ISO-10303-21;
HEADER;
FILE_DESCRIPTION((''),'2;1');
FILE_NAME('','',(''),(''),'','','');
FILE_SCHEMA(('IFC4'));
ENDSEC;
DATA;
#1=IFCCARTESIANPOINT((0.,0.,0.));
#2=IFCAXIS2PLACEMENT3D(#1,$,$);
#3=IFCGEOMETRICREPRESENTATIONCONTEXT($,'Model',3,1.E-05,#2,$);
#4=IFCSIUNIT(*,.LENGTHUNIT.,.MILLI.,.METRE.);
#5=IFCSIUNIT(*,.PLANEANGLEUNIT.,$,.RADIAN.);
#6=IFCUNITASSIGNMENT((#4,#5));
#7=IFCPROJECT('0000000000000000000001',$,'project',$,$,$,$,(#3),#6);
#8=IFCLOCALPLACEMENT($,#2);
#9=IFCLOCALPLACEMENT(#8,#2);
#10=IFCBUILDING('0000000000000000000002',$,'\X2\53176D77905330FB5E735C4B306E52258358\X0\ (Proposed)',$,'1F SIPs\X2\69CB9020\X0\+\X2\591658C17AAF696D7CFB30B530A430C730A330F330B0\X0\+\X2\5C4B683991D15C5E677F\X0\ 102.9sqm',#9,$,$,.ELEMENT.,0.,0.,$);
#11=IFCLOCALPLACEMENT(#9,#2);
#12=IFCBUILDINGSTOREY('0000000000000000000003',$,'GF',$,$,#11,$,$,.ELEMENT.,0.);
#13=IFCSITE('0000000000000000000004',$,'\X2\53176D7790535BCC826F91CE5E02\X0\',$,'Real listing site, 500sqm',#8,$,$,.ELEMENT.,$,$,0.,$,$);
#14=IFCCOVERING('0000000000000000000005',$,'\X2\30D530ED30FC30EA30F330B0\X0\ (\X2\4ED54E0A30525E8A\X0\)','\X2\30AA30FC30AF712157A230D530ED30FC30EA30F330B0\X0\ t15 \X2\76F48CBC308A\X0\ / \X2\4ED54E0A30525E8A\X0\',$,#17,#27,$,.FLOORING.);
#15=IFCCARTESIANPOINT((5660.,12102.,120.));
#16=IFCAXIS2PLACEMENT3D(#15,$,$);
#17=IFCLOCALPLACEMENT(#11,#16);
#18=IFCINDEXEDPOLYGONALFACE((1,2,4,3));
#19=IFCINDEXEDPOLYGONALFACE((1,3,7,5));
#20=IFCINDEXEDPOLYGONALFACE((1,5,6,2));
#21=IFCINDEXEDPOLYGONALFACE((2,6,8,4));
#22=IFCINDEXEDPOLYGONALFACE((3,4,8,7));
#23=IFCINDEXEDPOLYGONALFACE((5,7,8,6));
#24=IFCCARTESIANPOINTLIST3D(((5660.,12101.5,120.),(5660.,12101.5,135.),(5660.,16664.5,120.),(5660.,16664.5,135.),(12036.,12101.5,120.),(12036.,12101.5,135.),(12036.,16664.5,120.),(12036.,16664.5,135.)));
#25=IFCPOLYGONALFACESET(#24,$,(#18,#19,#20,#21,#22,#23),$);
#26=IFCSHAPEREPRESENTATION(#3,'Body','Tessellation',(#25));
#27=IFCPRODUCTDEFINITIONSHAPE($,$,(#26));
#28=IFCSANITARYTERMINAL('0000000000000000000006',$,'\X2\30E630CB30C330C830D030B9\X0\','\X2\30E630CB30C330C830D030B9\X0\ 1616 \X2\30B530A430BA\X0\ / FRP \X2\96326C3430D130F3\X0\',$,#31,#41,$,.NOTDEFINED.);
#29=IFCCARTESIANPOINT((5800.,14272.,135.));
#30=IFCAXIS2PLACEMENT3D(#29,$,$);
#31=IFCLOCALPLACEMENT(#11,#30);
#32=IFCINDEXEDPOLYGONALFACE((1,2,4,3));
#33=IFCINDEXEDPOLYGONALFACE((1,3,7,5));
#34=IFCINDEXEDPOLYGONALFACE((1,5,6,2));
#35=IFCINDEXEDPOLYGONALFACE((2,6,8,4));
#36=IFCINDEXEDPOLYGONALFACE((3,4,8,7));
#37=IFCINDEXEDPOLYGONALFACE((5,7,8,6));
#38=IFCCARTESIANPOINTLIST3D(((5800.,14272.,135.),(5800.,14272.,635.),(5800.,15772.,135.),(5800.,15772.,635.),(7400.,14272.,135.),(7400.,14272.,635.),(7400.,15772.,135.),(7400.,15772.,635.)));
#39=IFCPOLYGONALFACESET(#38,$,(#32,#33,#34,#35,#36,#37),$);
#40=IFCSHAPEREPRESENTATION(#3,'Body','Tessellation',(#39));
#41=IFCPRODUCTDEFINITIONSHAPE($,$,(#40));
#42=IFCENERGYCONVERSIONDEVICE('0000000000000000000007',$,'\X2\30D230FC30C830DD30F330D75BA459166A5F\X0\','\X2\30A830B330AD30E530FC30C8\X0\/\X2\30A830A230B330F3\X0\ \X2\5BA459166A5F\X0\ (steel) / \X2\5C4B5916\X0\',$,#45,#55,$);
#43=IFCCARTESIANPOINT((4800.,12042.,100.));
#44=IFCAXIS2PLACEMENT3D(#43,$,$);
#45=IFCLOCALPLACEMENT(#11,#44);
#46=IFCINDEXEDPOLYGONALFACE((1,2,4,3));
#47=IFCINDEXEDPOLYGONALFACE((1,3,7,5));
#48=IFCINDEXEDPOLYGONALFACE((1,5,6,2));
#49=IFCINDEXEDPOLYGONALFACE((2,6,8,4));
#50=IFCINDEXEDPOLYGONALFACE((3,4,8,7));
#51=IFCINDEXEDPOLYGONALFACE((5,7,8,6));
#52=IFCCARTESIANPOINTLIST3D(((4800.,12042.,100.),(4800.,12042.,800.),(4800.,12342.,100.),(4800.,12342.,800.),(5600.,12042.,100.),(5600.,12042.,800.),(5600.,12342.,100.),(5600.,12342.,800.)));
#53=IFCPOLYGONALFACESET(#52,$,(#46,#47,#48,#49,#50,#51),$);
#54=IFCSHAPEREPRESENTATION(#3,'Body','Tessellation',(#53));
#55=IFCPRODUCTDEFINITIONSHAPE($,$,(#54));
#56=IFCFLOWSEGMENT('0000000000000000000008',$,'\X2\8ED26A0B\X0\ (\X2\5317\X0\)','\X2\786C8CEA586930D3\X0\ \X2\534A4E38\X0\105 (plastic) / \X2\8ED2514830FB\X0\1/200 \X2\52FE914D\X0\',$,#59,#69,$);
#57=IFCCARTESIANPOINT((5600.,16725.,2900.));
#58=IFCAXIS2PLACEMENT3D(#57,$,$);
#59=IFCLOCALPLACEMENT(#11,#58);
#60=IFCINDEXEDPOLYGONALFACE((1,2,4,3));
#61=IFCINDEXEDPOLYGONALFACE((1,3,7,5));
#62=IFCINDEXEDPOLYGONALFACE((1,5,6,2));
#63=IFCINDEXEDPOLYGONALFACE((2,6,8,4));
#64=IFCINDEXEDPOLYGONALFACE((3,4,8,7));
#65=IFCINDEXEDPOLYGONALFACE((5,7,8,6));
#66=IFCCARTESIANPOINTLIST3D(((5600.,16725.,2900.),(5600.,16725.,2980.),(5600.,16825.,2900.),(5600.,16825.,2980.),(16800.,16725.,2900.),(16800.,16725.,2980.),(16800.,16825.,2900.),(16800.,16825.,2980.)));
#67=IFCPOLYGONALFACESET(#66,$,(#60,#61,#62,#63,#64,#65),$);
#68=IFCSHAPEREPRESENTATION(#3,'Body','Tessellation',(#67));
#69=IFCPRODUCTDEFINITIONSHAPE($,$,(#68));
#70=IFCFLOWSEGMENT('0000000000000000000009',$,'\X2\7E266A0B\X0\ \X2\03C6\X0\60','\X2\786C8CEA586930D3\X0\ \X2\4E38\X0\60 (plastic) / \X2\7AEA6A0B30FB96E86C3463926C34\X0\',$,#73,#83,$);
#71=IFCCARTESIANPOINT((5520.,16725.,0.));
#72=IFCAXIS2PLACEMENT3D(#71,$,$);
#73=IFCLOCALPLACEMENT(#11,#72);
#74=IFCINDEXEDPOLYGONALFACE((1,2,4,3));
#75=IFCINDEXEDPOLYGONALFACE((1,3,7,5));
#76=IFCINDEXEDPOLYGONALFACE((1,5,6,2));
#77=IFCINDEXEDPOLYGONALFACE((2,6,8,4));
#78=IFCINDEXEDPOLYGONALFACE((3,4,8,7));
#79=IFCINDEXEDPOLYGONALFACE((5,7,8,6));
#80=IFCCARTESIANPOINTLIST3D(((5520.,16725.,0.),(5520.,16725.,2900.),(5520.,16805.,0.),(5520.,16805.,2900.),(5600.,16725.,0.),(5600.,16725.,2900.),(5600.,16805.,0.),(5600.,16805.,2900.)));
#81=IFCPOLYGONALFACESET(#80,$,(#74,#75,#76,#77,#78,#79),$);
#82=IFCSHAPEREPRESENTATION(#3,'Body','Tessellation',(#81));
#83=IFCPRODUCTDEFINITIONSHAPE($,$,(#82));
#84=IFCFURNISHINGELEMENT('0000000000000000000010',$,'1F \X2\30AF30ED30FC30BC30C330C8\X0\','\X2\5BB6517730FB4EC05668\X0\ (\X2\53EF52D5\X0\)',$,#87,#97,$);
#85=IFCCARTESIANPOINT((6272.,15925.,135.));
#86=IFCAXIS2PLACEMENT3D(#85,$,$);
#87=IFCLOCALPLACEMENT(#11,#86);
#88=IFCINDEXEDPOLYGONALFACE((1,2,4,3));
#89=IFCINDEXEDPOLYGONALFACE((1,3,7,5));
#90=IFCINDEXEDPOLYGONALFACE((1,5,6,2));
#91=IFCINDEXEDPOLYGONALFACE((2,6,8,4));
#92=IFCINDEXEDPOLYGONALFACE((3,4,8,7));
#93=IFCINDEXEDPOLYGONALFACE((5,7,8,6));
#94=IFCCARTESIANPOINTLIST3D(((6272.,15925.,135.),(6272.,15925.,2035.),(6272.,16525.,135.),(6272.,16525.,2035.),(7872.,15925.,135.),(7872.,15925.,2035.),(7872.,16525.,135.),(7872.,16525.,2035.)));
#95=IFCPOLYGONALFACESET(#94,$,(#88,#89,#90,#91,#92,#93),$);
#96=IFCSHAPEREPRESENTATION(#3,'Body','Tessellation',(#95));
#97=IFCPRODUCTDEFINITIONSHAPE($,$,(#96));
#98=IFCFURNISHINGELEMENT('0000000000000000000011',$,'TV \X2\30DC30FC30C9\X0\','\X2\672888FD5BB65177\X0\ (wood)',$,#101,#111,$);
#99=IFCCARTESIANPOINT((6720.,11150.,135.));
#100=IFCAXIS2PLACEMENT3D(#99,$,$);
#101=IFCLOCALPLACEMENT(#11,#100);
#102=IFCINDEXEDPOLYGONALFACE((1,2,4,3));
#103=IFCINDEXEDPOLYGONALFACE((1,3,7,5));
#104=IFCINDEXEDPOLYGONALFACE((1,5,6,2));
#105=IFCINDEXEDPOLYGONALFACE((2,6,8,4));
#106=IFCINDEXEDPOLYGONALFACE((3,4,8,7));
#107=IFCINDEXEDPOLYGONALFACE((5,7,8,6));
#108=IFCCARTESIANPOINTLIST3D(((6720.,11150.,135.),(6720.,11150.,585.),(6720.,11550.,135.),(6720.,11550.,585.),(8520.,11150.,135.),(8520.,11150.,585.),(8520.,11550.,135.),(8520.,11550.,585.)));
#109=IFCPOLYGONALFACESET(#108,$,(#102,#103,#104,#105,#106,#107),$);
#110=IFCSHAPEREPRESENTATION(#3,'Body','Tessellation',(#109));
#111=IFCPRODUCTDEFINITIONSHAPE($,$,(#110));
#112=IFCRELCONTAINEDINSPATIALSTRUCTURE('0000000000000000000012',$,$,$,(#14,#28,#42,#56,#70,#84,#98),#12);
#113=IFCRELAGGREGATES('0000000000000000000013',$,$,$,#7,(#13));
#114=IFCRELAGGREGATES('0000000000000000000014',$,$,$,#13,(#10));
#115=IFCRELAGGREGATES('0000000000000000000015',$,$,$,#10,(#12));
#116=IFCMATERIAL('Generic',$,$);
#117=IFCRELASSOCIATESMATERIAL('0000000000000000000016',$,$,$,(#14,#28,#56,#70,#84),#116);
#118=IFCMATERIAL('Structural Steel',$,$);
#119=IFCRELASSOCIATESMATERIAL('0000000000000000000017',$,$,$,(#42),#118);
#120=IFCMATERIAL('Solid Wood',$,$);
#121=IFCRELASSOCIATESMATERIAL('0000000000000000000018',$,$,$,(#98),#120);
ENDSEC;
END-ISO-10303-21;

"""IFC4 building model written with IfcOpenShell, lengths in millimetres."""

from ifc_helpers import new_model, si_unit, frame, frame_2d, origin, place, context, project, spatial, rectangle, extrude, material, element, save


model = new_model("IFC4")

# Units and contexts
model_context = context("Model", 3, precision=1e-05, world=origin())
ifc_project = project(units=[si_unit("LENGTHUNIT", "METRE", prefix="MILLI"), si_unit("PLANEANGLEUNIT", "RADIAN")], contexts=[model_context])

# Site, building, storey
site_placement = place(None, origin())
site = spatial("IfcSite", under=ifc_project, at=site_placement, Name="北海道富良野市", ObjectType="Real listing site, 500sqm", CompositionType="ELEMENT", RefElevation=0.0)
building_placement = place(site_placement, origin())
building = spatial("IfcBuilding", under=site, at=building_placement, Name="北海道・平屋の別荘 (Proposed)", ObjectType="1F SIPs構造+外壁窯業系サイディング+屋根金属板 102.9sqm", CompositionType="ELEMENT", ElevationOfRefHeight=0.0, ElevationOfTerrain=0.0)
storey_placement = place(building_placement, origin())
storey = spatial("IfcBuildingStorey", under=building, at=storey_placement, Name="GF", CompositionType="ELEMENT", Elevation=0.0)

# Shared definitions
ifc_material_1 = material(Name="Solid Wood")

# Shared definitions
ifc_material_2 = material(Name="Structural Steel")

# Covering
ifc_material_3 = material(Name="Generic")
covering_placement = place(storey_placement, frame((5660.0, 12102.0, 120.0)))
element("IfcCovering", 1, at=covering_placement, inside=storey, material=ifc_material_3, Name="フローリング (仕上げ床)", Description="オーク無垢フローリング t15 直貼り / 仕上げ床", PredefinedType="FLOORING", context=model_context, shape_type="SweptSolid", body=[
    extrude(rectangle(XDim=6376.0, YDim=4563.0, at=frame_2d((3188.0, 2281.0))), frame((5660.0, 12102.0, 120.0)), (0.0, 0.0, 1.0), 15.0),
])

# Sanitary terminal
sanitary_terminal_placement = place(storey_placement, frame((5800.0, 14272.0, 135.0)))
element("IfcSanitaryTerminal", 2, at=sanitary_terminal_placement, inside=storey, material=ifc_material_3, Name="ユニットバス", Description="ユニットバス 1616 サイズ / FRP 防水パン", PredefinedType="NOTDEFINED", context=model_context, shape_type="SweptSolid", body=[
    extrude(rectangle(XDim=1600.0, YDim=1500.0, at=frame_2d((800.0, 750.0))), frame((5800.0, 14272.0, 135.0)), (0.0, 0.0, 1.0), 500.0),
])

# Energy conversion device
energy_conversion_device_placement = place(storey_placement, frame((4800.0, 12042.0, 100.0)))
element("IfcEnergyConversionDevice", 3, at=energy_conversion_device_placement, inside=storey, material=ifc_material_2, Name="ヒートポンプ室外機", Description="エコキュート/エアコン 室外機 (steel) / 屋外", context=model_context, shape_type="SweptSolid", body=[
    extrude(rectangle(XDim=800.0, YDim=300.0, at=frame_2d((400.0, 150.0))), frame((4800.0, 12042.0, 100.0)), (0.0, 0.0, 1.0), 700.0),
])

# Flow segments
flow_segment_1_placement = place(storey_placement, frame((5600.0, 16725.0, 2900.0)))
element("IfcFlowSegment", 4, at=flow_segment_1_placement, inside=storey, material=ifc_material_3, Name="軒樋 (北)", Description="硬質塩ビ 半丸105 (plastic) / 軒先・1/200 勾配", context=model_context, shape_type="SweptSolid", body=[
    extrude(rectangle(XDim=11200.0, YDim=100.0, at=frame_2d((5600.0, 50.0))), frame((5600.0, 16725.0, 2900.0)), (0.0, 0.0, 1.0), 80.0),
])
flow_segment_2_placement = place(storey_placement, frame((5520.0, 16725.0, 0.0)))
element("IfcFlowSegment", 5, at=flow_segment_2_placement, inside=storey, material=ifc_material_3, Name="縦樋 φ60", Description="硬質塩ビ 丸60 (plastic) / 竪樋・雨水排水", context=model_context, shape_type="SweptSolid", body=[
    extrude(rectangle(XDim=80.0, YDim=80.0, at=frame_2d((40.0, 40.0))), frame((5520.0, 16725.0, 0.0)), (0.0, 0.0, 1.0), 2900.0),
])

# Furnishing elements
furnishing_1_placement = place(storey_placement, frame((6272.0, 15925.0, 135.0)))
element("IfcFurnishingElement", 6, at=furnishing_1_placement, inside=storey, material=ifc_material_3, Name="1F クローゼット", Description="家具・什器 (可動)", context=model_context, shape_type="SweptSolid", body=[
    extrude(rectangle(XDim=1600.0, YDim=600.0, at=frame_2d((800.0, 300.0))), frame((6272.0, 15925.0, 135.0)), (0.0, 0.0, 1.0), 1900.0),
])
furnishing_2_placement = place(storey_placement, frame((6720.0, 11150.0, 135.0)))
element("IfcFurnishingElement", 7, at=furnishing_2_placement, inside=storey, material=ifc_material_1, Name="TV ボード", Description="木製家具 (wood)", context=model_context, shape_type="SweptSolid", body=[
    extrude(rectangle(XDim=1800.0, YDim=400.0, at=frame_2d((900.0, 200.0))), frame((6720.0, 11150.0, 135.0)), (0.0, 0.0, 1.0), 450.0),
])

save(model, "model.ifc")
